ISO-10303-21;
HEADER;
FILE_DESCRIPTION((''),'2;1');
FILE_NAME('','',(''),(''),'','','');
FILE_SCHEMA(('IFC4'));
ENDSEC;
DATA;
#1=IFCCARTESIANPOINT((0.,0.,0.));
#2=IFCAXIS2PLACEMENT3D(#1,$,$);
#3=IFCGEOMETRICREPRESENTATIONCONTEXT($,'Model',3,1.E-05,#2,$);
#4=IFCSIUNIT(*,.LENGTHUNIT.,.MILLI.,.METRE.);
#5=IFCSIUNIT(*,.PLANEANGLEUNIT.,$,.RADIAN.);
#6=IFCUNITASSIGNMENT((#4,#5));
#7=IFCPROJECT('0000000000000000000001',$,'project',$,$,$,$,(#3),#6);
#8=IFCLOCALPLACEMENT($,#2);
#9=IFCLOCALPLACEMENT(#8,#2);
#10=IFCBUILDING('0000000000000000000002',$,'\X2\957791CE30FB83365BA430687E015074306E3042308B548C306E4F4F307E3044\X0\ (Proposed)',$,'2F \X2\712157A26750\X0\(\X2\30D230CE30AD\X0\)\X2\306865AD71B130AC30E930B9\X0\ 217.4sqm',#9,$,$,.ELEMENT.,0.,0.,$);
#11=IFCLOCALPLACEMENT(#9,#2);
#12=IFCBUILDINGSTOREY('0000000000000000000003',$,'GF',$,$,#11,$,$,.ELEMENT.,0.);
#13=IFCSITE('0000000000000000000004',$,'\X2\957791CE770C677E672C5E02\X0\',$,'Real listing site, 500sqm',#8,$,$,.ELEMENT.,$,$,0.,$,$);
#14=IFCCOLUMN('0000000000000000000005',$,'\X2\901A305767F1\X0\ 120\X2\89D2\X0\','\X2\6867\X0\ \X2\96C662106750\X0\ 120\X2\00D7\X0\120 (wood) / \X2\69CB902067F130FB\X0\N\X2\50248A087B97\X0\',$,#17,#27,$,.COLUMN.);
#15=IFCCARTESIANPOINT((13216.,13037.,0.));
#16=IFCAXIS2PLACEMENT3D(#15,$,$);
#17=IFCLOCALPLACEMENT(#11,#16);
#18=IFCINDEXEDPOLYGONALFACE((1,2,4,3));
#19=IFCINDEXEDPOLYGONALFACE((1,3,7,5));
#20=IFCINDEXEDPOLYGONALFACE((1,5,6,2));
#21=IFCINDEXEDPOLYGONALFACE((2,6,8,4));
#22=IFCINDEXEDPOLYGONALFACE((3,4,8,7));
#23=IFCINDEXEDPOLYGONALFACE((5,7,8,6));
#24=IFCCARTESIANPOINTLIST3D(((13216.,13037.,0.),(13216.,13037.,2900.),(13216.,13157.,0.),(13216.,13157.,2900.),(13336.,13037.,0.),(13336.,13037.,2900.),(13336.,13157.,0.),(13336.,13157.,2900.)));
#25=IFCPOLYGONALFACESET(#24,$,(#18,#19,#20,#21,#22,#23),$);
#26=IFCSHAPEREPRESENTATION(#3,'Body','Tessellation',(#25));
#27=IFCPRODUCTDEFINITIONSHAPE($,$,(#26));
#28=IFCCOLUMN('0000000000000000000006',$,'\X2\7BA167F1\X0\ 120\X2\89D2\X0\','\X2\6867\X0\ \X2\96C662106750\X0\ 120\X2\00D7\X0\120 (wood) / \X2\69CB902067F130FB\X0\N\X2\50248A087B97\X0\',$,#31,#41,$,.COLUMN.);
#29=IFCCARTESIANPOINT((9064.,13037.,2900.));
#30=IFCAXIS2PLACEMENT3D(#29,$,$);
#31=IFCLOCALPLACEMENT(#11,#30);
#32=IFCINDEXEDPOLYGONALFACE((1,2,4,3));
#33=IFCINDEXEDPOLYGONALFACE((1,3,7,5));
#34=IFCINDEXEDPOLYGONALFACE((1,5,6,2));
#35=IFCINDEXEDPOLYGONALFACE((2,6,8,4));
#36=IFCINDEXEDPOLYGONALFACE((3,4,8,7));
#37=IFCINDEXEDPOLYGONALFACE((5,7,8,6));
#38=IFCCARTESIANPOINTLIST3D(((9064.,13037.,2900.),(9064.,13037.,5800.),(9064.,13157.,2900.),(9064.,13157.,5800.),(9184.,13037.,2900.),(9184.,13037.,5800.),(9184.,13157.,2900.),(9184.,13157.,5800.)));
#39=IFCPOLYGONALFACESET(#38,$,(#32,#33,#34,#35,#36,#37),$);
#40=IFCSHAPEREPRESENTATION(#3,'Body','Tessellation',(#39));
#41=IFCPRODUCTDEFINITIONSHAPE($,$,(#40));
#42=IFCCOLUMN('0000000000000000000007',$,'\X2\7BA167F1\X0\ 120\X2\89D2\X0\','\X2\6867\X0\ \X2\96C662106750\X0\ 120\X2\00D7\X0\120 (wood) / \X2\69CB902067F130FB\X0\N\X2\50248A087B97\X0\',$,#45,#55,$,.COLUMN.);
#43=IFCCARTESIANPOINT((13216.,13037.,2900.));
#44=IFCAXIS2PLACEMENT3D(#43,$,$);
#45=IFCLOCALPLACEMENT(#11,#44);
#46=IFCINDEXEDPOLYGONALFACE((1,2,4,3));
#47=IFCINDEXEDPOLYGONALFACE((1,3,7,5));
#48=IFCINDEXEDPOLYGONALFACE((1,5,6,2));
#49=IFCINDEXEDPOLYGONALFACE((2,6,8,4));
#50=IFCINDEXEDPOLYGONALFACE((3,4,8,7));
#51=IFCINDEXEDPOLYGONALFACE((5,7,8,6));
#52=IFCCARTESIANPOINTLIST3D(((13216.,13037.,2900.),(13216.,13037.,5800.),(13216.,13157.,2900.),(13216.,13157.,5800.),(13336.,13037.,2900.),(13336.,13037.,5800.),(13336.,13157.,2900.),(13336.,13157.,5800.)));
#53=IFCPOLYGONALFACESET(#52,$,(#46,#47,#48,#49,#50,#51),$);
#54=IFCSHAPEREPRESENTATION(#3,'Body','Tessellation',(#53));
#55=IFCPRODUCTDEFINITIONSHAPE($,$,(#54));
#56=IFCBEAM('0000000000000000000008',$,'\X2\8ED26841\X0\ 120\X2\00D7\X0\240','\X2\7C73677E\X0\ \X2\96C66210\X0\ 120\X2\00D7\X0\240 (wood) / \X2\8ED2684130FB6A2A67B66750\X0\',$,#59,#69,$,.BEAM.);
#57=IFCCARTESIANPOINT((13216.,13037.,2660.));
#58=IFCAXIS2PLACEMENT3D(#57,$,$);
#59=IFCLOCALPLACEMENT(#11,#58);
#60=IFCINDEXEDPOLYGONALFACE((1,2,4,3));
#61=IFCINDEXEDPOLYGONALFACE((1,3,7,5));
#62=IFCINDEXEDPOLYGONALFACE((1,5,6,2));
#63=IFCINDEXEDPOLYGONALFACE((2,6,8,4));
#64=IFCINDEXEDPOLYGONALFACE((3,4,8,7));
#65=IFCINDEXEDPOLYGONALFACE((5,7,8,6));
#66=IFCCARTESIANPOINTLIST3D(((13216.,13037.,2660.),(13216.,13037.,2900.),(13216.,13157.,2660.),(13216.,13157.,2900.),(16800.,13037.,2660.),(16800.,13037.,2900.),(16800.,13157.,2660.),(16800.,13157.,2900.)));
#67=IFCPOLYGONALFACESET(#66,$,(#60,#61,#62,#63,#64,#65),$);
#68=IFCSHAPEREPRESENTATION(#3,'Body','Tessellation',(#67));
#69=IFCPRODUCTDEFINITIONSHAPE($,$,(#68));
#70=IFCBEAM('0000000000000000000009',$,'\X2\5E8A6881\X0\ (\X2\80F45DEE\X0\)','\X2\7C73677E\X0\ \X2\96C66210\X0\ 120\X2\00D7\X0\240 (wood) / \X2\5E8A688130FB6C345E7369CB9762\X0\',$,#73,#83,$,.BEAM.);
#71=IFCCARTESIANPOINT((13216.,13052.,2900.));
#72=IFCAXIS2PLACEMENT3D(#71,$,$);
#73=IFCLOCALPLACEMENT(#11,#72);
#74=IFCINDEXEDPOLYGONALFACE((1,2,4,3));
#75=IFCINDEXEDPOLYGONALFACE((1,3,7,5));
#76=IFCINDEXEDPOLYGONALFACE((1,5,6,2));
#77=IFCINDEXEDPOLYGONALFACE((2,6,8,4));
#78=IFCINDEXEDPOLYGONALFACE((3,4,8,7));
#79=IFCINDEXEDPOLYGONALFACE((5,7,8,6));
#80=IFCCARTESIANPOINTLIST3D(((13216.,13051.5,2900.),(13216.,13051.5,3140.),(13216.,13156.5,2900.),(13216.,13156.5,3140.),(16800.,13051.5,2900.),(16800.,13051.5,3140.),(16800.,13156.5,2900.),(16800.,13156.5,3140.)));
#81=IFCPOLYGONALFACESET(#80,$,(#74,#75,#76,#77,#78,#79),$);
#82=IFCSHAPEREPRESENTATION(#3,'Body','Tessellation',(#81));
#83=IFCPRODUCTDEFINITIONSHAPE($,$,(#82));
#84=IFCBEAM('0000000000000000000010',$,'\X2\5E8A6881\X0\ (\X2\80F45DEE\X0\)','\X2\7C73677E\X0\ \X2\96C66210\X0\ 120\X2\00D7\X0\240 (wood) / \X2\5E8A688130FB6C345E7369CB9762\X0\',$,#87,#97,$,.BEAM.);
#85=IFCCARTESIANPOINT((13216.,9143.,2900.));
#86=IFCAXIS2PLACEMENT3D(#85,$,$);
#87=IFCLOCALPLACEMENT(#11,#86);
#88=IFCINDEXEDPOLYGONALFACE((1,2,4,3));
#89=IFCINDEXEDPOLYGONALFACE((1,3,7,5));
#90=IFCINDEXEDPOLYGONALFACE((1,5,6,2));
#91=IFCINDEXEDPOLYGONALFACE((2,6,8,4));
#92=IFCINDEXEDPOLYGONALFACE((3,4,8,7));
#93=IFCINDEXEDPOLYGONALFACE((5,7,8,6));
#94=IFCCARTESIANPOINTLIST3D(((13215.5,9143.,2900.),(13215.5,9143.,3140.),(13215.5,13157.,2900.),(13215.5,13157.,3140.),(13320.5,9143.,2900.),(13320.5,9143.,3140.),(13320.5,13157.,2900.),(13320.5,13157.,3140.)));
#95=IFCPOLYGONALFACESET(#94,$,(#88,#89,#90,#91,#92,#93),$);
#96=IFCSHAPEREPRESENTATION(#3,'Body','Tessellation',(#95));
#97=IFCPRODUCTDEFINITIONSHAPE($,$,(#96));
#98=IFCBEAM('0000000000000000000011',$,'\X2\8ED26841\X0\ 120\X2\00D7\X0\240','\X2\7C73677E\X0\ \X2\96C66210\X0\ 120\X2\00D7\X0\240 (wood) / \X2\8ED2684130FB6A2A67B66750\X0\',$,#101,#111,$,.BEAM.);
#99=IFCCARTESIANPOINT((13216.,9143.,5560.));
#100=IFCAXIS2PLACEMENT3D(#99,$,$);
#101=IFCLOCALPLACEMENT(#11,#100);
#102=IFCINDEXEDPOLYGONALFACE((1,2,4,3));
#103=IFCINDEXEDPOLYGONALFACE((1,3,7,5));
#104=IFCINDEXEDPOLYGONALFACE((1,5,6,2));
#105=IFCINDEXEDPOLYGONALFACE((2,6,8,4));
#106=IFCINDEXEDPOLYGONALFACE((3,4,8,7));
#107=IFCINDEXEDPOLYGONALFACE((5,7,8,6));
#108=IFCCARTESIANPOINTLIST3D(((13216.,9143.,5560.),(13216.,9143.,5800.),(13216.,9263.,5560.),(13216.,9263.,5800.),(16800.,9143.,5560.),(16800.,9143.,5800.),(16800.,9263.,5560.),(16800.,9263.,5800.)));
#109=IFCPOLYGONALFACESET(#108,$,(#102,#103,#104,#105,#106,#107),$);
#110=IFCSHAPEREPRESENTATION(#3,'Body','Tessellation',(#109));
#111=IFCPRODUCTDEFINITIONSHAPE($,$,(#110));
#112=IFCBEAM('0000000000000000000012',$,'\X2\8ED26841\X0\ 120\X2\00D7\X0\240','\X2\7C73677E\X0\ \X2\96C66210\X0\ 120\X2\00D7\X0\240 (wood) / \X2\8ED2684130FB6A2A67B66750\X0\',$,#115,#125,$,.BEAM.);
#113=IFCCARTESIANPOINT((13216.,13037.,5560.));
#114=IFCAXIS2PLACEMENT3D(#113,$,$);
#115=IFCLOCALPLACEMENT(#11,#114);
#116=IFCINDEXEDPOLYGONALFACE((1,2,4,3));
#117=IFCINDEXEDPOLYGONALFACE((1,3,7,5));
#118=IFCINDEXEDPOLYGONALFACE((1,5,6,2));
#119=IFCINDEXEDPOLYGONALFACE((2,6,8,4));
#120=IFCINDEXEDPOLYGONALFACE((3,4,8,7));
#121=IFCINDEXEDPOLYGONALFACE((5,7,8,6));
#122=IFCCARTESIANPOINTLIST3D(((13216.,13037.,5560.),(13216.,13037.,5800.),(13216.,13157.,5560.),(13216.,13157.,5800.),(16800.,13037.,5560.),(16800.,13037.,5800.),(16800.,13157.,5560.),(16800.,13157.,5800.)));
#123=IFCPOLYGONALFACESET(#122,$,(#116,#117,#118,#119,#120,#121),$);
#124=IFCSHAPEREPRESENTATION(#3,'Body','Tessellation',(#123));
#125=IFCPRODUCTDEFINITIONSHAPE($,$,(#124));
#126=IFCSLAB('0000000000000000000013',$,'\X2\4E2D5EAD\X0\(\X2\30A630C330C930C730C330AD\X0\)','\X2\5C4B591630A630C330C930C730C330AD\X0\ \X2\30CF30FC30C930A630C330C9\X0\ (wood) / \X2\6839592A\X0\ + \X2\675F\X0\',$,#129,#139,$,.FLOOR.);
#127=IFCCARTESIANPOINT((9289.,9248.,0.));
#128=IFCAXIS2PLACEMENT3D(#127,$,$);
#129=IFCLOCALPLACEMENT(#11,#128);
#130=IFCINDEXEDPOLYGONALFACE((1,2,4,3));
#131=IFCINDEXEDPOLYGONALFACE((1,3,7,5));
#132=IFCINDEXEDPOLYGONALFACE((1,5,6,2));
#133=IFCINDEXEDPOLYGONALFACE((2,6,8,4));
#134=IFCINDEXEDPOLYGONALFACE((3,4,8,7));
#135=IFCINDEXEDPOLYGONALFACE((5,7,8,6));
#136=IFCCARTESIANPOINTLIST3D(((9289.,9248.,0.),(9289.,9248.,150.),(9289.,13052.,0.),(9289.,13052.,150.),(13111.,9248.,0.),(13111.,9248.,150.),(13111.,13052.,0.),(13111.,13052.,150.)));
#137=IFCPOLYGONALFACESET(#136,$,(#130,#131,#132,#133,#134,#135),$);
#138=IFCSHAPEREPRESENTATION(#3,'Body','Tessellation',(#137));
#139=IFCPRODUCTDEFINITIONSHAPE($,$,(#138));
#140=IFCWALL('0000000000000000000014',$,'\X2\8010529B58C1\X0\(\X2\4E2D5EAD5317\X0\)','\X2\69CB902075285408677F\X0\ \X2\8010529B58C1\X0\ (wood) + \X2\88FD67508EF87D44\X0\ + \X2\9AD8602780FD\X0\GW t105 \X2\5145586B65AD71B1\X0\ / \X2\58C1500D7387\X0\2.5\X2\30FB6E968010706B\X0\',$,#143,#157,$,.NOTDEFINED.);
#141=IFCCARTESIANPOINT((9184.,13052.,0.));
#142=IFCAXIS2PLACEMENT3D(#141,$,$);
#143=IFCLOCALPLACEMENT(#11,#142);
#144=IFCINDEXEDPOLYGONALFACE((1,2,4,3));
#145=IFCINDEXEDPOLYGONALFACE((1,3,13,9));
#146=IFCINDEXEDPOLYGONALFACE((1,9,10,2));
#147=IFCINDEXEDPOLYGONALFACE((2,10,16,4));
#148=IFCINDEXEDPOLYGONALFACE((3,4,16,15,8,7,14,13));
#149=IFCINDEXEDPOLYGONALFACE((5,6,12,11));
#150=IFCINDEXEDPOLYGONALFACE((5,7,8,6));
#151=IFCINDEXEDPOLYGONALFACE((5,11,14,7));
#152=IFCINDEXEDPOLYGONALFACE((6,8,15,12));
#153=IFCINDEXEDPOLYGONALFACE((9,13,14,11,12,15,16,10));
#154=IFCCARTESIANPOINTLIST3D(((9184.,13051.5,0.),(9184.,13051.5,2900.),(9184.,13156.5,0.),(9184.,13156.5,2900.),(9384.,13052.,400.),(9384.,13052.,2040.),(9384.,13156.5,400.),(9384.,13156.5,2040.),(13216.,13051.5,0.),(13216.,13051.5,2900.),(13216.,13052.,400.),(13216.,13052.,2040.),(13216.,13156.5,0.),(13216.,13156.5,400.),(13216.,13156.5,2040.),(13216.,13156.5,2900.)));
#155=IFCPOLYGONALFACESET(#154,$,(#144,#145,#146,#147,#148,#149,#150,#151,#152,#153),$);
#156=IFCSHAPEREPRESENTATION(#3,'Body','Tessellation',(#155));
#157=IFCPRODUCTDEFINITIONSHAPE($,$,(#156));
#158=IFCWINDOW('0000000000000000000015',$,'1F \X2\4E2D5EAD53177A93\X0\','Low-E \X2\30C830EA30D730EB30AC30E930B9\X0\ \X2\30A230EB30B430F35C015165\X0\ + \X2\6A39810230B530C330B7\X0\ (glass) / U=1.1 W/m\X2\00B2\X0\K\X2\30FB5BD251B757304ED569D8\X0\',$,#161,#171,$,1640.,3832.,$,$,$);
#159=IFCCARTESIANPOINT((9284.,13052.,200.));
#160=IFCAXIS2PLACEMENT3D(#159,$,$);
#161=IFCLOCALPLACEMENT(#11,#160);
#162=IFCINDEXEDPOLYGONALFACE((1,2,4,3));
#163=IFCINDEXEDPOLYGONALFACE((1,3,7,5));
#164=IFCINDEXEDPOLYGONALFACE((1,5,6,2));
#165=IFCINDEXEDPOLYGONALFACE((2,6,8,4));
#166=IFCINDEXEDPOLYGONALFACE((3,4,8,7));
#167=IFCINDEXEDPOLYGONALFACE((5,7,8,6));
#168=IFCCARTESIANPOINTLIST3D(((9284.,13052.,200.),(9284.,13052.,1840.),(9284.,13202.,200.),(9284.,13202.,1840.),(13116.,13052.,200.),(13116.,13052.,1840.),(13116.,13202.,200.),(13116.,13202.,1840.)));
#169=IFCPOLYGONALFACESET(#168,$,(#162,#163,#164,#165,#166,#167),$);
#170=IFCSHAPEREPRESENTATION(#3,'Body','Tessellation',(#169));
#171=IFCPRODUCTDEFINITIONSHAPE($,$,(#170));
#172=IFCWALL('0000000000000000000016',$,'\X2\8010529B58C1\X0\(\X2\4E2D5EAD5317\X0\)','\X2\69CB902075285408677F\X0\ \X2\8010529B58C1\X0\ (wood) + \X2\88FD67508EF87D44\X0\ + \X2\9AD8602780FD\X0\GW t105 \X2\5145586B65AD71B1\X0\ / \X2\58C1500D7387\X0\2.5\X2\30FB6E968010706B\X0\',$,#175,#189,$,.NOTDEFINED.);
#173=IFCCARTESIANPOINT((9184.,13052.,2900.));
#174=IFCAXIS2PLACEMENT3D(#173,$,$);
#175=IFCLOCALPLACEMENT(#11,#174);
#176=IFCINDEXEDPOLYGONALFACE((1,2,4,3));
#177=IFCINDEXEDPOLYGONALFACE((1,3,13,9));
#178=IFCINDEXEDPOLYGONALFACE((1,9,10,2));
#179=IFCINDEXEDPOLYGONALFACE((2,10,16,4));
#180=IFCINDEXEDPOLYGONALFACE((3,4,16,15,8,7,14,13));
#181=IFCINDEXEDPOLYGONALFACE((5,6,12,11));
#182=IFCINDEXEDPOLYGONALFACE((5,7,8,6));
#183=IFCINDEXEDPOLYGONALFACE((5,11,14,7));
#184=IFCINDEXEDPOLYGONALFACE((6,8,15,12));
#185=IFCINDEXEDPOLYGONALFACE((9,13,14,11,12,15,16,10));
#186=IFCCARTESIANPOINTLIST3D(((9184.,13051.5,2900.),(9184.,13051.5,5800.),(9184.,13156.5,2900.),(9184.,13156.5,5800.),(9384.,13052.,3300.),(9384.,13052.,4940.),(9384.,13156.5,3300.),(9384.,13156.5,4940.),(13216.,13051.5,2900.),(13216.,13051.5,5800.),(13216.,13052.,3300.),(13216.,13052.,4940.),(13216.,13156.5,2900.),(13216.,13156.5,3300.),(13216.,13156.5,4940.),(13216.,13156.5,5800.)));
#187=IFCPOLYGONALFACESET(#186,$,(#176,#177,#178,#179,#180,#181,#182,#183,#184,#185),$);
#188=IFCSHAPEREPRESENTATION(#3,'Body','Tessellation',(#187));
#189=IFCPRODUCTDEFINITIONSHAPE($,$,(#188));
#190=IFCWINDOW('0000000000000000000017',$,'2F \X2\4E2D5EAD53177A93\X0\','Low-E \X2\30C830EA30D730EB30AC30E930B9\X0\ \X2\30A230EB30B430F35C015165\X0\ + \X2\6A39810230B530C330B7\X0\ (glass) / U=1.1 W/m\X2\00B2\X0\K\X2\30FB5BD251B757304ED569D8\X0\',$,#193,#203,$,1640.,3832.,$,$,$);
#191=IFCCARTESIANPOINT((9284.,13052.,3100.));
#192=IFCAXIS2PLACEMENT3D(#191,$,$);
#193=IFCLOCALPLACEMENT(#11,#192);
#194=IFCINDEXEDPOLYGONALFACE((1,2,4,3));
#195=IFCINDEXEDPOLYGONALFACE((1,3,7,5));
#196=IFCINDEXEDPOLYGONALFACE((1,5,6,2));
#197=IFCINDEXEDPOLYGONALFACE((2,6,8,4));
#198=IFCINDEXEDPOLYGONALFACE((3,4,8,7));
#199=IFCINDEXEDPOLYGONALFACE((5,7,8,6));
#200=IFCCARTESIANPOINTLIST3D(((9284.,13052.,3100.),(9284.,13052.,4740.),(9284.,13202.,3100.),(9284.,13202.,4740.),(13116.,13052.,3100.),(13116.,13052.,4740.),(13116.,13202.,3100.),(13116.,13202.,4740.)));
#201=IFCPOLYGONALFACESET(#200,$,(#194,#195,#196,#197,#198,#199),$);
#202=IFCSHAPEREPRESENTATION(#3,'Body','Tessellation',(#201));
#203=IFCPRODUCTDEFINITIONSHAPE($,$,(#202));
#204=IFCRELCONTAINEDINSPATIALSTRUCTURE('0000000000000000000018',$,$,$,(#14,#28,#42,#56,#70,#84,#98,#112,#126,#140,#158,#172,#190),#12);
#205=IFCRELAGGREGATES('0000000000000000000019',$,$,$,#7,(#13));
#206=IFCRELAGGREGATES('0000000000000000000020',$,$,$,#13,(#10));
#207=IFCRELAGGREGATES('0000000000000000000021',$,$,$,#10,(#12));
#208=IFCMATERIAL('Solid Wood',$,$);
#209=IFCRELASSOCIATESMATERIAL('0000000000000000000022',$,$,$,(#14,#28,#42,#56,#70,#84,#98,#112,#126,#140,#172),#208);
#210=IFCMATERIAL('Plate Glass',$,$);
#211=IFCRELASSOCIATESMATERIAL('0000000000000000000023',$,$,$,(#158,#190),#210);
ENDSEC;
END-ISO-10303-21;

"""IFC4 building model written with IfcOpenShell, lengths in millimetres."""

from ifc_helpers import new_model, si_unit, frame, frame_2d, origin, place, context, project, spatial, rectangle, extrude, material, element, fill, save


model = new_model("IFC4")

# Units and contexts
model_context = context("Model", 3, precision=1e-05, world=origin())
ifc_project = project(units=[si_unit("LENGTHUNIT", "METRE", prefix="MILLI"), si_unit("PLANEANGLEUNIT", "RADIAN")], contexts=[model_context])

# Site, building, storey
site_placement = place(None, origin())
site = spatial("IfcSite", under=ifc_project, at=site_placement, Name="長野県松本市", ObjectType="Real listing site, 500sqm", CompositionType="ELEMENT", RefElevation=0.0)
building_placement = place(site_placement, origin())
building = spatial("IfcBuilding", under=site, at=building_placement, Name="長野・茶室と縁側のある和の住まい (Proposed)", ObjectType="2F 無垢材(ヒノキ)と断熱ガラス 217.4sqm", CompositionType="ELEMENT", ElevationOfRefHeight=0.0, ElevationOfTerrain=0.0)
storey_placement = place(building_placement, origin())
storey = spatial("IfcBuildingStorey", under=building, at=storey_placement, Name="GF", CompositionType="ELEMENT", Elevation=0.0)

# Columns
ifc_material_1 = material(Name="Solid Wood")
column_1_placement = place(storey_placement, frame((13216.0, 13037.0, 0.0)))
element("IfcColumn", 1, at=column_1_placement, inside=storey, material=ifc_material_1, Name="通し柱 120角", Description="桧 集成材 120×120 (wood) / 構造柱・N値計算", PredefinedType="COLUMN", context=model_context, shape_type="SweptSolid", body=[
    extrude(rectangle(XDim=120.0, YDim=120.0, at=frame_2d((60.0, 60.0))), frame((13216.0, 13037.0, 0.0)), (0.0, 0.0, 1.0), 2900.0),
])
column_2_placement = place(storey_placement, frame((9064.0, 13037.0, 2900.0)))
element("IfcColumn", 2, at=column_2_placement, inside=storey, material=ifc_material_1, Name="管柱 120角", Description="桧 集成材 120×120 (wood) / 構造柱・N値計算", PredefinedType="COLUMN", context=model_context, shape_type="SweptSolid", body=[
    extrude(rectangle(XDim=120.0, YDim=120.0, at=frame_2d((60.0, 60.0))), frame((9064.0, 13037.0, 2900.0)), (0.0, 0.0, 1.0), 2900.0),
])
column_3_placement = place(storey_placement, frame((13216.0, 13037.0, 2900.0)))
element("IfcColumn", 3, at=column_3_placement, inside=storey, material=ifc_material_1, Name="管柱 120角", Description="桧 集成材 120×120 (wood) / 構造柱・N値計算", PredefinedType="COLUMN", context=model_context, shape_type="SweptSolid", body=[
    extrude(rectangle(XDim=120.0, YDim=120.0, at=frame_2d((60.0, 60.0))), frame((13216.0, 13037.0, 2900.0)), (0.0, 0.0, 1.0), 2900.0),
])

# Beams
beam_1_placement = place(storey_placement, frame((13216.0, 13037.0, 2660.0)))
element("IfcBeam", 4, at=beam_1_placement, inside=storey, material=ifc_material_1, Name="軒桁 120×240", Description="米松 集成 120×240 (wood) / 軒桁・横架材", PredefinedType="BEAM", context=model_context, shape_type="SweptSolid", body=[
    extrude(rectangle(XDim=3584.0, YDim=120.0, at=frame_2d((1792.0, 60.0))), frame((13216.0, 13037.0, 2660.0)), (0.0, 0.0, 1.0), 240.0),
])
beam_2_placement = place(storey_placement, frame((13216.0, 13052.0, 2900.0)))
element("IfcBeam", 5, at=beam_2_placement, inside=storey, material=ifc_material_1, Name="床梁 (胴差)", Description="米松 集成 120×240 (wood) / 床梁・水平構面", PredefinedType="BEAM", context=model_context, shape_type="SweptSolid", body=[
    extrude(rectangle(XDim=3584.0, YDim=105.0, at=frame_2d((1792.0, 52.0))), frame((13216.0, 13052.0, 2900.0)), (0.0, 0.0, 1.0), 240.0),
])
beam_3_placement = place(storey_placement, frame((13216.0, 9143.0, 2900.0)))
element("IfcBeam", 6, at=beam_3_placement, inside=storey, material=ifc_material_1, Name="床梁 (胴差)", Description="米松 集成 120×240 (wood) / 床梁・水平構面", PredefinedType="BEAM", context=model_context, shape_type="SweptSolid", body=[
    extrude(rectangle(XDim=105.0, YDim=4014.0, at=frame_2d((52.0, 2007.0))), frame((13216.0, 9143.0, 2900.0)), (0.0, 0.0, 1.0), 240.0),
])
beam_4_placement = place(storey_placement, frame((13216.0, 9143.0, 5560.0)))
element("IfcBeam", 7, at=beam_4_placement, inside=storey, material=ifc_material_1, Name="軒桁 120×240", Description="米松 集成 120×240 (wood) / 軒桁・横架材", PredefinedType="BEAM", context=model_context, shape_type="SweptSolid", body=[
    extrude(rectangle(XDim=3584.0, YDim=120.0, at=frame_2d((1792.0, 60.0))), frame((13216.0, 9143.0, 5560.0)), (0.0, 0.0, 1.0), 240.0),
])
beam_5_placement = place(storey_placement, frame((13216.0, 13037.0, 5560.0)))
element("IfcBeam", 8, at=beam_5_placement, inside=storey, material=ifc_material_1, Name="軒桁 120×240", Description="米松 集成 120×240 (wood) / 軒桁・横架材", PredefinedType="BEAM", context=model_context, shape_type="SweptSolid", body=[
    extrude(rectangle(XDim=3584.0, YDim=120.0, at=frame_2d((1792.0, 60.0))), frame((13216.0, 13037.0, 5560.0)), (0.0, 0.0, 1.0), 240.0),
])

# Slab
slab_placement = place(storey_placement, frame((9289.0, 9248.0, 0.0)))
element("IfcSlab", 9, at=slab_placement, inside=storey, material=ifc_material_1, Name="中庭(ウッドデッキ)", Description="屋外ウッドデッキ ハードウッド (wood) / 根太 + 束", PredefinedType="FLOOR", context=model_context, shape_type="SweptSolid", body=[
    extrude(rectangle(XDim=3822.0, YDim=3804.0, at=frame_2d((1911.0, 1902.0))), frame((9289.0, 9248.0, 0.0)), (0.0, 0.0, 1.0), 150.0),
])

# Wall, opening, window
wall_1_placement = place(storey_placement, frame((9184.0, 13052.0, 0.0)))
wall_1 = element("IfcWall", 10, at=wall_1_placement, inside=storey, material=ifc_material_1, Name="耐力壁(中庭北)", Description="構造用合板 耐力壁 (wood) + 製材軸組 + 高性能GW t105 充填断熱 / 壁倍率2.5・準耐火", PredefinedType="NOTDEFINED", context=model_context, shape_type="SweptSolid", body=[
    extrude(rectangle(XDim=4032.0, YDim=105.0, at=frame_2d((2016.0, 52.0))), frame((9184.0, 13052.0, 0.0)), (0.0, 0.0, 1.0), 2900.0),
])
opening_1_placement = place(storey_placement, frame((9284.0, 13052.0, 200.0)))
opening_1 = element("IfcOpeningElement", 11, at=opening_1_placement, cuts=wall_1, PredefinedType="NOTDEFINED", context=model_context, shape_type="SweptSolid", body=[
    extrude(rectangle(XDim=3832.0, YDim=150.0, at=frame_2d((1916.0, 75.0))), frame((9284.0, 13052.0, 200.0)), (0.0, 0.0, 1.0), 1640.0),
])
ifc_material_2 = material(Name="Plate Glass")
window_1_placement = place(storey_placement, frame((9284.0, 13052.0, 200.0)))
window_1 = element("IfcWindow", 12, at=window_1_placement, inside=storey, material=ifc_material_2, Name="1F 中庭北窓", Description="Low-E トリプルガラス アルゴン封入 + 樹脂サッシ (glass) / U=1.1 W/m²K・寒冷地仕様", OverallHeight=1640.0, OverallWidth=3832.0, context=model_context, shape_type="SweptSolid", body=[
    extrude(rectangle(XDim=3832.0, YDim=150.0, at=frame_2d((1916.0, 75.0))), frame((9284.0, 13052.0, 200.0)), (0.0, 0.0, 1.0), 1640.0),
])
fill(opening_1, window_1)

# Wall, opening, window
wall_2_placement = place(storey_placement, frame((9184.0, 13052.0, 2900.0)))
wall_2 = element("IfcWall", 13, at=wall_2_placement, inside=storey, material=ifc_material_1, Name="耐力壁(中庭北)", Description="構造用合板 耐力壁 (wood) + 製材軸組 + 高性能GW t105 充填断熱 / 壁倍率2.5・準耐火", PredefinedType="NOTDEFINED", context=model_context, shape_type="SweptSolid", body=[
    extrude(rectangle(XDim=4032.0, YDim=105.0, at=frame_2d((2016.0, 52.0))), frame((9184.0, 13052.0, 2900.0)), (0.0, 0.0, 1.0), 2900.0),
])
opening_2_placement = place(storey_placement, frame((9284.0, 13052.0, 3100.0)))
opening_2 = element("IfcOpeningElement", 14, at=opening_2_placement, cuts=wall_2, PredefinedType="NOTDEFINED", context=model_context, shape_type="SweptSolid", body=[
    extrude(rectangle(XDim=3832.0, YDim=150.0, at=frame_2d((1916.0, 75.0))), frame((9284.0, 13052.0, 3100.0)), (0.0, 0.0, 1.0), 1640.0),
])
window_2_placement = place(storey_placement, frame((9284.0, 13052.0, 3100.0)))
window_2 = element("IfcWindow", 15, at=window_2_placement, inside=storey, material=ifc_material_2, Name="2F 中庭北窓", Description="Low-E トリプルガラス アルゴン封入 + 樹脂サッシ (glass) / U=1.1 W/m²K・寒冷地仕様", OverallHeight=1640.0, OverallWidth=3832.0, context=model_context, shape_type="SweptSolid", body=[
    extrude(rectangle(XDim=3832.0, YDim=150.0, at=frame_2d((1916.0, 75.0))), frame((9284.0, 13052.0, 3100.0)), (0.0, 0.0, 1.0), 1640.0),
])
fill(opening_2, window_2)

save(model, "model.ifc")
